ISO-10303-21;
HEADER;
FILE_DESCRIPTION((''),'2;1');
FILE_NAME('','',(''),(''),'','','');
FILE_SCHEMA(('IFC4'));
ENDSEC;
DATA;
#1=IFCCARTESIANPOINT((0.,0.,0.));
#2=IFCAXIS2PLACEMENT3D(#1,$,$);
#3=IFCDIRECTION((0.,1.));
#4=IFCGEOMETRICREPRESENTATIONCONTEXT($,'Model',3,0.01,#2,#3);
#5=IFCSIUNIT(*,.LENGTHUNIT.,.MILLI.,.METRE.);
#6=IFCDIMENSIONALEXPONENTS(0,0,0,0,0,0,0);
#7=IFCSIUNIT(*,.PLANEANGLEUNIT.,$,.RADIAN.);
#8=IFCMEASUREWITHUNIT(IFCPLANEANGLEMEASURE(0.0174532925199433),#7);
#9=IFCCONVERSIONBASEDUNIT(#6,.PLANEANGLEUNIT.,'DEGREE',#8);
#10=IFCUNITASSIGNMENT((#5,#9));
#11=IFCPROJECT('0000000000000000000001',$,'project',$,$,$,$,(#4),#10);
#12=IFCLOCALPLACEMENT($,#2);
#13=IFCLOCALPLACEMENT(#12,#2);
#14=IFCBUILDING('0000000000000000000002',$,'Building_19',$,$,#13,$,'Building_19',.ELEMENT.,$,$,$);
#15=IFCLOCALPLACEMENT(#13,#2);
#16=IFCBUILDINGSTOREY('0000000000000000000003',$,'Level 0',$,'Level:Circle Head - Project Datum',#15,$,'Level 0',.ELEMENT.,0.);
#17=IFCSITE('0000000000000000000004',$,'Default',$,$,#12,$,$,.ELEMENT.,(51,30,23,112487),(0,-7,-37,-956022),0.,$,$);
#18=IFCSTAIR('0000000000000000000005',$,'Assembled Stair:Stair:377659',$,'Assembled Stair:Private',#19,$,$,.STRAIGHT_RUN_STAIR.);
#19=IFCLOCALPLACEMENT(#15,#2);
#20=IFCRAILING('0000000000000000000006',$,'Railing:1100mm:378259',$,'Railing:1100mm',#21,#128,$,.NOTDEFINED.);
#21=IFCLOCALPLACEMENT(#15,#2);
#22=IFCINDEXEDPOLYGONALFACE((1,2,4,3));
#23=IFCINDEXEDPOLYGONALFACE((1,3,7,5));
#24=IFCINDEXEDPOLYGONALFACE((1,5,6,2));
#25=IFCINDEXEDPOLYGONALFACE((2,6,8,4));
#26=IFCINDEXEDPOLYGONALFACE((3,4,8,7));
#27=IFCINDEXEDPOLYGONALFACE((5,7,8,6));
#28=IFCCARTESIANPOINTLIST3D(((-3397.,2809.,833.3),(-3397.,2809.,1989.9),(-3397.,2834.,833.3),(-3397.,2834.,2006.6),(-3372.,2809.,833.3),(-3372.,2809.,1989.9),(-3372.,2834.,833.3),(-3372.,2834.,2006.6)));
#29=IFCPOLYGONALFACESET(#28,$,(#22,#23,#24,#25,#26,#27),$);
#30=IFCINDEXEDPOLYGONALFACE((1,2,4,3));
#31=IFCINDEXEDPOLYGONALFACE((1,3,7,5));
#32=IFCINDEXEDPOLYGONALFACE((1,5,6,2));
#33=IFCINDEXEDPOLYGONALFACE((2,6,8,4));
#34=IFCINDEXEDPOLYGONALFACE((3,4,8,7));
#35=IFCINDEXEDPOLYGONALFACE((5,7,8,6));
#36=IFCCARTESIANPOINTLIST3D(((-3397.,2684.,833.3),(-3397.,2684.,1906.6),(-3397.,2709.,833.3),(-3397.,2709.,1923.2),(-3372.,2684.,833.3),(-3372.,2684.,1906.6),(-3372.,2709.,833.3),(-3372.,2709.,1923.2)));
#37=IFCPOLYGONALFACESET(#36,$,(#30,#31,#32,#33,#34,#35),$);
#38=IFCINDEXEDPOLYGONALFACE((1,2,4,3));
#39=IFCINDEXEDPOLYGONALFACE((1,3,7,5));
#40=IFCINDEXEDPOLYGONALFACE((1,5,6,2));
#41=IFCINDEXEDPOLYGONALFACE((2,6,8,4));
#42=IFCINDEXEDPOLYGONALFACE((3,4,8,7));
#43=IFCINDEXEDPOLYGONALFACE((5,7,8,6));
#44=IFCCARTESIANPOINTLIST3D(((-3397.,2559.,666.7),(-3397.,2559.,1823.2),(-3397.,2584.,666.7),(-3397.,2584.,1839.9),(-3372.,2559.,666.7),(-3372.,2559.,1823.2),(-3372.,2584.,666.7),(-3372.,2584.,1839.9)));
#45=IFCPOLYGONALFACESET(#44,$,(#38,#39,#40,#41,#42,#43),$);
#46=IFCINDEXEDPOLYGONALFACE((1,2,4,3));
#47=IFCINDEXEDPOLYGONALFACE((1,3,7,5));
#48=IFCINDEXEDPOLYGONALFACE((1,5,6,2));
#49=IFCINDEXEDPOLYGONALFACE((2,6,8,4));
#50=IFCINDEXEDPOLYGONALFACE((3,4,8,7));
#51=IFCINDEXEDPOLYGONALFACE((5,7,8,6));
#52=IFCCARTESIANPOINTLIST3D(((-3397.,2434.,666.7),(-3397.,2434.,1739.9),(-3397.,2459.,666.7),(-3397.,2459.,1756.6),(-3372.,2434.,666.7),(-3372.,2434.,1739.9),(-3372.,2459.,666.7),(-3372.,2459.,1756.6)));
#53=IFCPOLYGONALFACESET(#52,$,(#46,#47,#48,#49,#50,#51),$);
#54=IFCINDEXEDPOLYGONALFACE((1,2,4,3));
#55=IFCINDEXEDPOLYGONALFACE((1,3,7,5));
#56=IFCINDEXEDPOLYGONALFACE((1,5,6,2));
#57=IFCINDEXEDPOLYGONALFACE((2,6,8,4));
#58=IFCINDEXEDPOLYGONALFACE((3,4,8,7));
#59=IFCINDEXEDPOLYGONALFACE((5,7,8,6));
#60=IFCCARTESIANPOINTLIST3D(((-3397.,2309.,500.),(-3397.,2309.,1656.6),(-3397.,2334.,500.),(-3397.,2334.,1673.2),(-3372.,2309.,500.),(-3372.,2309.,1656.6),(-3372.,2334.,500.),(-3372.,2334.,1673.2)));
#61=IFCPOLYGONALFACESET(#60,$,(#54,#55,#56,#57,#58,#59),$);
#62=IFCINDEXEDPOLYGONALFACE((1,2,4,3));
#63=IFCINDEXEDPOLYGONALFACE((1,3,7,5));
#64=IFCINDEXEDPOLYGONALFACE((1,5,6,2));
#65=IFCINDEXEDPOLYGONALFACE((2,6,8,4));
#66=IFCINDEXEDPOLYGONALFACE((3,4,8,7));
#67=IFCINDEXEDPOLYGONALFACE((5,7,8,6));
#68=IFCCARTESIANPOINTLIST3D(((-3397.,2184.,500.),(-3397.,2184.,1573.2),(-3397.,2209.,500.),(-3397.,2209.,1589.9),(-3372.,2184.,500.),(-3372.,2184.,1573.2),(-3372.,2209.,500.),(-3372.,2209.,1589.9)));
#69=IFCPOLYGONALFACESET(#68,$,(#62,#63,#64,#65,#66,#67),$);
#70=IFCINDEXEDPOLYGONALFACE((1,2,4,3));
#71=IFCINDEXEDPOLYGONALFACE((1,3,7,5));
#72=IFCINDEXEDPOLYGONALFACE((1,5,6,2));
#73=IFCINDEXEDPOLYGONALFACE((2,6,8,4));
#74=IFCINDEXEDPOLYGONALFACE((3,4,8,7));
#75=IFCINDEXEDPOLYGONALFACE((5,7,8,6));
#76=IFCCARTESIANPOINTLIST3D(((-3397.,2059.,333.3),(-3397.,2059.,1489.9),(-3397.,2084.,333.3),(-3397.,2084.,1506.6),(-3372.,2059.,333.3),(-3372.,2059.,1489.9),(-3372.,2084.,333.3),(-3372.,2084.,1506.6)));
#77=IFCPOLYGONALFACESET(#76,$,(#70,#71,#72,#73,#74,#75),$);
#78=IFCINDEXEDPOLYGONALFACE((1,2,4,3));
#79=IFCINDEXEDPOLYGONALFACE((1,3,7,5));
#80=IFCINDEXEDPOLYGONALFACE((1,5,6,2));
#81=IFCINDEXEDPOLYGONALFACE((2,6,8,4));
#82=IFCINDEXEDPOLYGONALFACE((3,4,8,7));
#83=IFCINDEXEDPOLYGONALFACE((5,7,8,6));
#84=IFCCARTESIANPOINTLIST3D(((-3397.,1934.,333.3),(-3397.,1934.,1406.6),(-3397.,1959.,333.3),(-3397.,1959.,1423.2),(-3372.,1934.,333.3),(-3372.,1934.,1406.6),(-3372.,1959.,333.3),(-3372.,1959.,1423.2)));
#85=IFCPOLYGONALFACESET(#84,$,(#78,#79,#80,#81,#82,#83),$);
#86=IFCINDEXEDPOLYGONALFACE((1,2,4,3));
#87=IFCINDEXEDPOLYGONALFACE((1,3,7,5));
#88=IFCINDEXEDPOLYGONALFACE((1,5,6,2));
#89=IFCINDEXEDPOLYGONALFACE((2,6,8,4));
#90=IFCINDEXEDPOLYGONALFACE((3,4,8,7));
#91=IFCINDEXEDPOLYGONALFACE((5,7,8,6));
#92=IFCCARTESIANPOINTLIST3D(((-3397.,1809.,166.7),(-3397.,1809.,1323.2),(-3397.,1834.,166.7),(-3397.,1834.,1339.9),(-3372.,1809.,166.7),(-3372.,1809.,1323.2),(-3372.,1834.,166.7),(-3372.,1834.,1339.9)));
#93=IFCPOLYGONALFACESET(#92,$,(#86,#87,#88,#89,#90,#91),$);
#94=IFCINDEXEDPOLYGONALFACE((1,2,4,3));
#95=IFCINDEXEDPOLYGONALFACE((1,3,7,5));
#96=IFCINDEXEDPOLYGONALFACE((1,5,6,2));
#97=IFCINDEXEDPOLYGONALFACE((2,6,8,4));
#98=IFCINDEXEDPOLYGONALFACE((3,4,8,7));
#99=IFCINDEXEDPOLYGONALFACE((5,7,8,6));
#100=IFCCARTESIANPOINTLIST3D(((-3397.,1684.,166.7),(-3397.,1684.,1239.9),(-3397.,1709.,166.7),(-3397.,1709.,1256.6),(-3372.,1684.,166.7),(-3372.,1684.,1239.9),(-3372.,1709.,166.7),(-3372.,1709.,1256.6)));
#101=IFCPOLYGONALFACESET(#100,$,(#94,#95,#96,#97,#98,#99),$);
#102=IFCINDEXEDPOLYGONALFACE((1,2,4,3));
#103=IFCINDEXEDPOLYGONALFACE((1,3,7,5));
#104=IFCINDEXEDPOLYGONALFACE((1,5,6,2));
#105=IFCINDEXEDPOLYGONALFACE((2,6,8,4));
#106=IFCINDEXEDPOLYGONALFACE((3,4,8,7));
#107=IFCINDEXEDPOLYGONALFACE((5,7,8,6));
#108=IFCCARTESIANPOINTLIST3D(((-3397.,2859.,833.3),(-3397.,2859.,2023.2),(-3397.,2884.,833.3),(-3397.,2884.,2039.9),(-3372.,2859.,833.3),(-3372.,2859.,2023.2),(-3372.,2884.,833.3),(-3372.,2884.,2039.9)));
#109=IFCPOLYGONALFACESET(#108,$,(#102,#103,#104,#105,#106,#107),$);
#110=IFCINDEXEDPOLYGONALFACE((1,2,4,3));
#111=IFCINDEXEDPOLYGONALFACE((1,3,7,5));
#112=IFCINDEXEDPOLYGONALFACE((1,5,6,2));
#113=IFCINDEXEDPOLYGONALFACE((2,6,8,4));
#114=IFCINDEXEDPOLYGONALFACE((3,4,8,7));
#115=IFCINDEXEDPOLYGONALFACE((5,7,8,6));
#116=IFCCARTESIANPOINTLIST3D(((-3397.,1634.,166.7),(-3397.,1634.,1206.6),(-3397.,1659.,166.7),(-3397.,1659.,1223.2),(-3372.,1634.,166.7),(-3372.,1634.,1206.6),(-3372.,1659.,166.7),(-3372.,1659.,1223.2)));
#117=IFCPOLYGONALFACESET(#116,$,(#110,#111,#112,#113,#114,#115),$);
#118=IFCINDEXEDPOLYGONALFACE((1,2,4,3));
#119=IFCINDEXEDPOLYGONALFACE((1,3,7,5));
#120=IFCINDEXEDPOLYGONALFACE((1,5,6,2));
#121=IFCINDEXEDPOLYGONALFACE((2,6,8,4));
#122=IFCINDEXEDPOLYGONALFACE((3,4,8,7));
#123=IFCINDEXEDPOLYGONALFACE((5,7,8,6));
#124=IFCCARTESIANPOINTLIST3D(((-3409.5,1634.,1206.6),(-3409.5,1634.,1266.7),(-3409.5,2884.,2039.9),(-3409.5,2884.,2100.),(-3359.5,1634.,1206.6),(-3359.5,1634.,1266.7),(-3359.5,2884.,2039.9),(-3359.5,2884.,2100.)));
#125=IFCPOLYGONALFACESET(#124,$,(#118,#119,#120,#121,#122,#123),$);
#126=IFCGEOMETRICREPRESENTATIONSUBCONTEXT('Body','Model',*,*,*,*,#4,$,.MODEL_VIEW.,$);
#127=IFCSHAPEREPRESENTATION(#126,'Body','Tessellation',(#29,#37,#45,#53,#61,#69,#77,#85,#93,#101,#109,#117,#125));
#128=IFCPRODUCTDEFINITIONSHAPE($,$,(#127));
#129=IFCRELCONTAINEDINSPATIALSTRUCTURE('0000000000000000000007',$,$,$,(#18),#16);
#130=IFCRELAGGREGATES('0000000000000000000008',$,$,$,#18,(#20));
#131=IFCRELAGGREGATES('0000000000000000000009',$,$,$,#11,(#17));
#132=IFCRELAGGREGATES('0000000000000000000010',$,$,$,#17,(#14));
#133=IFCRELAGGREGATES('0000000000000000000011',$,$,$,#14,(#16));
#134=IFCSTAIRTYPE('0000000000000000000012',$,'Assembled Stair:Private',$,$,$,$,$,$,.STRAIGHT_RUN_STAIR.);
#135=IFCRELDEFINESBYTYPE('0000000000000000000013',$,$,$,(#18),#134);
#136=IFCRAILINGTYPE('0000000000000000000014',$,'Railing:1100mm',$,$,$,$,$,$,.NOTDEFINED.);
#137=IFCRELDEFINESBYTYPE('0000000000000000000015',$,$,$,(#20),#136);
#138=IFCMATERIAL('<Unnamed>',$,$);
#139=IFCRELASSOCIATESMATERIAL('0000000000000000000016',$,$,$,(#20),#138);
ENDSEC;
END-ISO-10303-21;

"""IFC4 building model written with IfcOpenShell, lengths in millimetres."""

from ifc_helpers import new_model, entity, si_unit, converted_unit, direction, frame, origin, place, context, subcontext, project, spatial, indexed_curve, outline, extrude, material, type_object, element, aggregate, save


model = new_model("IFC4")

# Units and contexts
model_context = context("Model", 3, precision=0.01, world=origin(), true_north=direction((0.0, 1.0)))
body_context = subcontext(model_context, "Body", "Model", "MODEL_VIEW")
ifc_project = project(units=[si_unit("LENGTHUNIT", "METRE", prefix="MILLI"), converted_unit("PLANEANGLEUNIT", "DEGREE", entity("IfcPlaneAngleMeasure", 0.0174532925199433), si_unit("PLANEANGLEUNIT", "RADIAN"), dimensions=[0, 0, 0, 0, 0, 0, 0])], contexts=[model_context])

# Site, building, storey
site_placement = place(None, origin())
site = spatial("IfcSite", under=ifc_project, at=site_placement, Name="Default", CompositionType="ELEMENT", RefLatitude=(51, 30, 23, 112487), RefLongitude=(0, -7, -37, -956022), RefElevation=0.0)
building_placement = place(site_placement, origin())
building = spatial("IfcBuilding", under=site, at=building_placement, Name="Building_19", LongName="Building_19", CompositionType="ELEMENT")
storey_placement = place(building_placement, origin())
storey = spatial("IfcBuildingStorey", under=building, at=storey_placement, Name="Level 0", ObjectType="Level:Circle Head - Project Datum", LongName="Level 0", CompositionType="ELEMENT", Elevation=0.0)

# Stair, railing
stair_type = type_object("IfcStairType", Name="Assembled Stair:Private", PredefinedType="STRAIGHT_RUN_STAIR")
stair_1_placement = place(storey_placement, origin())
stair_1 = element("IfcStair", 1, at=stair_1_placement, inside=storey, type_object=stair_type, Name="Assembled Stair:Stair:377659", ObjectType="Assembled Stair:Private", PredefinedType="STRAIGHT_RUN_STAIR")
ifc_material_1 = material(Name="<Unnamed>")
railing_type = type_object("IfcRailingType", Name="Railing:1100mm", PredefinedType="NOTDEFINED")
railing_1_placement = place(stair_1_placement, origin())
railing_1 = element("IfcRailing", 2, at=railing_1_placement, type_object=railing_type, material=ifc_material_1, Name="Railing:1100mm:378259", ObjectType="Railing:1100mm", PredefinedType="NOTDEFINED", context=body_context, shape_type="SweptSolid", body=[
    extrude(outline(indexed_curve([(-574.1, -12.5), (582.5, -12.5), (582.5, 12.5), (-590.8, 12.5), (-574.1, -12.5)], self_intersect=False)), frame((-3397.0, 2821.5, 1415.8), z_axis=(1.0, 0.0, 0.0), x_axis=(0.0, 0.0, -1.0)), (0.0, 0.0, 1.0), 25.0),
    extrude(outline(indexed_curve([(-532.5, -12.5), (540.8, -12.5), (540.8, 12.5), (-549.1, 12.5), (-532.5, -12.5)], self_intersect=False)), frame((-3397.0, 2696.5, 1374.1), z_axis=(1.0, 0.0, 0.0), x_axis=(0.0, 0.0, -1.0)), (0.0, 0.0, 1.0), 25.0),
    extrude(outline(indexed_curve([(-574.1, -12.5), (582.5, -12.5), (582.5, 12.5), (-590.8, 12.5), (-574.1, -12.5)], self_intersect=False)), frame((-3397.0, 2571.5, 1249.1), z_axis=(1.0, 0.0, 0.0), x_axis=(0.0, 0.0, -1.0)), (0.0, 0.0, 1.0), 25.0),
    extrude(outline(indexed_curve([(-532.5, -12.5), (540.8, -12.5), (540.8, 12.5), (-549.1, 12.5), (-532.5, -12.5)], self_intersect=False)), frame((-3397.0, 2446.5, 1207.5), z_axis=(1.0, 0.0, 0.0), x_axis=(0.0, 0.0, -1.0)), (0.0, 0.0, 1.0), 25.0),
    extrude(outline(indexed_curve([(-574.1, -12.5), (582.5, -12.5), (582.5, 12.5), (-590.8, 12.5), (-574.1, -12.5)], self_intersect=False)), frame((-3397.0, 2321.5, 1082.5), z_axis=(1.0, 0.0, 0.0), x_axis=(0.0, 0.0, -1.0)), (0.0, 0.0, 1.0), 25.0),
    extrude(outline(indexed_curve([(-532.5, -12.5), (540.8, -12.5), (540.8, 12.5), (-549.1, 12.5), (-532.5, -12.5)], self_intersect=False)), frame((-3397.0, 2196.5, 1040.8), z_axis=(1.0, 0.0, 0.0), x_axis=(0.0, 0.0, -1.0)), (0.0, 0.0, 1.0), 25.0),
    extrude(outline(indexed_curve([(-574.1, -12.5), (582.5, -12.5), (582.5, 12.5), (-590.8, 12.5), (-574.1, -12.5)], self_intersect=False)), frame((-3397.0, 2071.5, 915.8), z_axis=(1.0, 0.0, 0.0), x_axis=(0.0, 0.0, -1.0)), (0.0, 0.0, 1.0), 25.0),
    extrude(outline(indexed_curve([(-532.5, -12.5), (540.8, -12.5), (540.8, 12.5), (-549.1, 12.5), (-532.5, -12.5)], self_intersect=False)), frame((-3397.0, 1946.5, 874.1), z_axis=(1.0, 0.0, 0.0), x_axis=(0.0, 0.0, -1.0)), (0.0, 0.0, 1.0), 25.0),
    extrude(outline(indexed_curve([(-574.1, -12.5), (582.5, -12.5), (582.5, 12.5), (-590.8, 12.5), (-574.1, -12.5)], self_intersect=False)), frame((-3397.0, 1821.5, 749.1), z_axis=(1.0, 0.0, 0.0), x_axis=(0.0, 0.0, -1.0)), (0.0, 0.0, 1.0), 25.0),
    extrude(outline(indexed_curve([(-532.5, -12.5), (540.8, -12.5), (540.8, 12.5), (-549.1, 12.5), (-532.5, -12.5)], self_intersect=False)), frame((-3397.0, 1696.5, 707.5), z_axis=(1.0, 0.0, 0.0), x_axis=(0.0, 0.0, -1.0)), (0.0, 0.0, 1.0), 25.0),
    extrude(outline(indexed_curve([(-590.8, -12.5), (599.1, -12.5), (599.1, 12.5), (-607.5, 12.5), (-590.8, -12.5)], self_intersect=False)), frame((-3397.0, 2871.5, 1432.5), z_axis=(1.0, 0.0, 0.0), x_axis=(0.0, 0.0, -1.0)), (0.0, 0.0, 1.0), 25.0),
    extrude(outline(indexed_curve([(-515.8, -12.5), (524.1, -12.5), (524.1, 12.5), (-532.5, 12.5), (-515.8, -12.5)], self_intersect=False)), frame((-3397.0, 1646.5, 690.8), z_axis=(1.0, 0.0, 0.0), x_axis=(0.0, 0.0, -1.0)), (0.0, 0.0, 1.0), 25.0),
    extrude(outline(indexed_curve([(-767.8, -25.0), (734.5, -25.0), (767.8, 25.0), (-734.5, 25.0), (-767.8, -25.0)], self_intersect=False)), frame((-3409.5, 2259.0, 1653.3), z_axis=(1.0, 0.0, 0.0), x_axis=(0.0, 0.83205, 0.5547)), (0.0, 0.0, 1.0), 50.0),
])
aggregate(stair_1, [railing_1])

save(model, "model.ifc")
